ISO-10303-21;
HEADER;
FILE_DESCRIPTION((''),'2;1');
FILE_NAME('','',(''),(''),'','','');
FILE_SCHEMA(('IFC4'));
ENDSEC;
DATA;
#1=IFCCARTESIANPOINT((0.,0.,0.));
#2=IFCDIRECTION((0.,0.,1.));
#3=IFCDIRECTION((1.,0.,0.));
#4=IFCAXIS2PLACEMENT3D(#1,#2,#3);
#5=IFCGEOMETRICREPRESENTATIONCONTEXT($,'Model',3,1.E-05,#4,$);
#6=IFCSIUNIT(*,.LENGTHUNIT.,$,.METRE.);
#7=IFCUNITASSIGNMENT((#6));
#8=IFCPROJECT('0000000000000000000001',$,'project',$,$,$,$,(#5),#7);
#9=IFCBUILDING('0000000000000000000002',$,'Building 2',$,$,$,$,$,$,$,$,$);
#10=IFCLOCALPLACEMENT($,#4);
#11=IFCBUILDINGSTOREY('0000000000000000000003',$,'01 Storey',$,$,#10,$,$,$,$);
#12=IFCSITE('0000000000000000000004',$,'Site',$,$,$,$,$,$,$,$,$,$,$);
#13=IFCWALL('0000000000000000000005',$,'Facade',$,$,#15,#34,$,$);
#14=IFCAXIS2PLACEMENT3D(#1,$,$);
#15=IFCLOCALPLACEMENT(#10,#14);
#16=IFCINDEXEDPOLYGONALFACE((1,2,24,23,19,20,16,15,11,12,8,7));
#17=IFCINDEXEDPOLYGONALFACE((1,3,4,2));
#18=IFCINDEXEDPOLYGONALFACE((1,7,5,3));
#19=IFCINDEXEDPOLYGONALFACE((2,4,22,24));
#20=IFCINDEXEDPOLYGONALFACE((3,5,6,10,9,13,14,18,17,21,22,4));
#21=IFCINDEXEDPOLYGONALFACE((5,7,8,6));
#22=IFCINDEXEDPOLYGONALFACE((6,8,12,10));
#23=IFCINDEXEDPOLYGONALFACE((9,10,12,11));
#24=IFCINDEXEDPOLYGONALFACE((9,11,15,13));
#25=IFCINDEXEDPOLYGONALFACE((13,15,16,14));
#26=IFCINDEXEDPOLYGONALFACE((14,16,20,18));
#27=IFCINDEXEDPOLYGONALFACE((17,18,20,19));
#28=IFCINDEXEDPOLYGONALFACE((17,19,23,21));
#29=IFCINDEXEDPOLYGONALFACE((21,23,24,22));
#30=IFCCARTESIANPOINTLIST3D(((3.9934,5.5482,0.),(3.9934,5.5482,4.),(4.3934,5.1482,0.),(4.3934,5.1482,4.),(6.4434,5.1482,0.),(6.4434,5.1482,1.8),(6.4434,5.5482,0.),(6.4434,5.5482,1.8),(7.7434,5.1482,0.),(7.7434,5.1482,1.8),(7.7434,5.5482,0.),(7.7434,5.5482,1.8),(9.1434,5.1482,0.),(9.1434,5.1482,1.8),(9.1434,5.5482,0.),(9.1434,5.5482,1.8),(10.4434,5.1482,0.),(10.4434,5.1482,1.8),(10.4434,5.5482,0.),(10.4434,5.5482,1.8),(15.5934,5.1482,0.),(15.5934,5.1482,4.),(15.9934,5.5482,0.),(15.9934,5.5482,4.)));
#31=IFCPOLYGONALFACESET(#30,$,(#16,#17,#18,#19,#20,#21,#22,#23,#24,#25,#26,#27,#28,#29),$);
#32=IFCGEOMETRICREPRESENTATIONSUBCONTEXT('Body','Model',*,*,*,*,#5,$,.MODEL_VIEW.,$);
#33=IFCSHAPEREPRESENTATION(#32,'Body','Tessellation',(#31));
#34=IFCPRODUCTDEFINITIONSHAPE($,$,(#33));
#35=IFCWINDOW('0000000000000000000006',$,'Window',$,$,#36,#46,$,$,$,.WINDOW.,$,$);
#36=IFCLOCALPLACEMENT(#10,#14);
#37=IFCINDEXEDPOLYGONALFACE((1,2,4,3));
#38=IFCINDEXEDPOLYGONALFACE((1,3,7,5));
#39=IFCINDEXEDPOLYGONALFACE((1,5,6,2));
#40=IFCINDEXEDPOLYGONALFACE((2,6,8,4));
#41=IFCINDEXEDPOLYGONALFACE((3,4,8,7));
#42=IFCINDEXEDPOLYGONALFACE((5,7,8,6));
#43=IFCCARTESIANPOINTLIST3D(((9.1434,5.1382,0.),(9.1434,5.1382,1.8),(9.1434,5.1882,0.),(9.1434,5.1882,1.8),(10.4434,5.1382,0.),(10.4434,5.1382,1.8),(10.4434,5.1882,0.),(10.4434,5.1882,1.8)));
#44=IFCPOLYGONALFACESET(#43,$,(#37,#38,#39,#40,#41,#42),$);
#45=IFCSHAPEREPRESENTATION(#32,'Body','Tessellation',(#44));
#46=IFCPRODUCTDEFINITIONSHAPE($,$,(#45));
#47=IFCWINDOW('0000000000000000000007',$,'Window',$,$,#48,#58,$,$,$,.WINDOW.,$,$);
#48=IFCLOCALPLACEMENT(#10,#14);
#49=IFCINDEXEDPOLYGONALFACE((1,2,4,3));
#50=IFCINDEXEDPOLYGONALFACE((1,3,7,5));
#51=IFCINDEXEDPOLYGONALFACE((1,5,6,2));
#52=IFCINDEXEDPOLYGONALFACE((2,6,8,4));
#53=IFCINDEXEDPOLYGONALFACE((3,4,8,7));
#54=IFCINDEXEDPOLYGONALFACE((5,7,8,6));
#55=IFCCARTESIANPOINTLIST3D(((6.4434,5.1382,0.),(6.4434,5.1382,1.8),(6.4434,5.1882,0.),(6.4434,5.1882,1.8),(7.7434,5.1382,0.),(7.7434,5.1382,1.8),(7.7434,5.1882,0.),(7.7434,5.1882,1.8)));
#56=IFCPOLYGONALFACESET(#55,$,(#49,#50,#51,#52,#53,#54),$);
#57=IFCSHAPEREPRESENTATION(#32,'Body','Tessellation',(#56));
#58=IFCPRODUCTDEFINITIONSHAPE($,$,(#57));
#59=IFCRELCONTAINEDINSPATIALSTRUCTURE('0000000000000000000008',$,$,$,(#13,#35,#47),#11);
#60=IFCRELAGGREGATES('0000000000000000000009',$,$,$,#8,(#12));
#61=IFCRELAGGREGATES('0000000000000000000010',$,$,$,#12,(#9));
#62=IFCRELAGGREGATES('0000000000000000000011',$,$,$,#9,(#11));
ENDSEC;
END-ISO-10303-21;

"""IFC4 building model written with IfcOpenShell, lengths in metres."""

from ifc_helpers import new_model, si_unit, origin_with_axes, place, context, subcontext, project, spatial, line, indexed_curve, outline, extrude, element, fill, save


model = new_model("IFC4")

# Units and contexts
model_context = context("Model", 3, precision=1e-05, world=origin_with_axes())
body_context = subcontext(model_context, "Body", "Model", "MODEL_VIEW")
ifc_project = project(units=[si_unit("LENGTHUNIT", "METRE")], contexts=[model_context])

# Site, building, storey
site = spatial("IfcSite", under=ifc_project, Name="Site")
building = spatial("IfcBuilding", under=site, Name="Building 2")
storey_placement = place(None, origin_with_axes())
storey = spatial("IfcBuildingStorey", under=building, at=storey_placement, Name="01 Storey")

# Wall, openings, windows
wall_1_placement = place(storey_placement, origin_with_axes())
wall_1 = element("IfcWall", 1, at=wall_1_placement, inside=storey, Name="Facade", context=body_context, shape_type="SweptSolid", body=[
    extrude(outline(indexed_curve([(15.5934, 5.1482), (4.3934, 5.1482), (3.9934, 5.5482), (15.9934, 5.5482)], segments=[line(1, 2), line(2, 3), line(3, 4)])), origin_with_axes(), (0.0, 0.0, 1.0), 4.0),
])
opening_1_placement = place(wall_1_placement, origin_with_axes())
opening_1 = element("IfcOpeningElement", 2, at=opening_1_placement, cuts=wall_1, context=body_context, shape_type="SweptSolid", body=[
    extrude(outline(indexed_curve([(10.4434, 5.5882), (10.4434, 5.0882), (9.1434, 5.0882), (9.1434, 5.5882)], segments=[line(1, 2), line(2, 3), line(3, 4)])), origin_with_axes(), (0.0, 0.0, 1.0), 1.8),
])
opening_2_placement = place(wall_1_placement, origin_with_axes())
opening_2 = element("IfcOpeningElement", 3, at=opening_2_placement, cuts=wall_1, context=body_context, shape_type="SweptSolid", body=[
    extrude(outline(indexed_curve([(7.7434, 5.5882), (7.7434, 5.0882), (6.4434, 5.0882), (6.4434, 5.5882)], segments=[line(1, 2), line(2, 3), line(3, 4)])), origin_with_axes(), (0.0, 0.0, 1.0), 1.8),
])
window_1_placement = place(storey_placement, origin_with_axes())
window_1 = element("IfcWindow", 4, at=window_1_placement, inside=storey, Name="Window", PredefinedType="WINDOW", context=body_context, shape_type="SweptSolid", body=[
    extrude(outline(indexed_curve([(10.4434, 5.1882), (10.4434, 5.1382), (9.1434, 5.1382), (9.1434, 5.1882)], segments=[line(1, 2), line(2, 3), line(3, 4)])), origin_with_axes(), (0.0, 0.0, 1.0), 1.8),
])
fill(opening_1, window_1)
window_2_placement = place(storey_placement, origin_with_axes())
window_2 = element("IfcWindow", 5, at=window_2_placement, inside=storey, Name="Window", PredefinedType="WINDOW", context=body_context, shape_type="SweptSolid", body=[
    extrude(outline(indexed_curve([(7.7434, 5.1882), (7.7434, 5.1382), (6.4434, 5.1382), (6.4434, 5.1882)], segments=[line(1, 2), line(2, 3), line(3, 4)])), origin_with_axes(), (0.0, 0.0, 1.0), 1.8),
])
fill(opening_2, window_2)

save(model, "model.ifc")
